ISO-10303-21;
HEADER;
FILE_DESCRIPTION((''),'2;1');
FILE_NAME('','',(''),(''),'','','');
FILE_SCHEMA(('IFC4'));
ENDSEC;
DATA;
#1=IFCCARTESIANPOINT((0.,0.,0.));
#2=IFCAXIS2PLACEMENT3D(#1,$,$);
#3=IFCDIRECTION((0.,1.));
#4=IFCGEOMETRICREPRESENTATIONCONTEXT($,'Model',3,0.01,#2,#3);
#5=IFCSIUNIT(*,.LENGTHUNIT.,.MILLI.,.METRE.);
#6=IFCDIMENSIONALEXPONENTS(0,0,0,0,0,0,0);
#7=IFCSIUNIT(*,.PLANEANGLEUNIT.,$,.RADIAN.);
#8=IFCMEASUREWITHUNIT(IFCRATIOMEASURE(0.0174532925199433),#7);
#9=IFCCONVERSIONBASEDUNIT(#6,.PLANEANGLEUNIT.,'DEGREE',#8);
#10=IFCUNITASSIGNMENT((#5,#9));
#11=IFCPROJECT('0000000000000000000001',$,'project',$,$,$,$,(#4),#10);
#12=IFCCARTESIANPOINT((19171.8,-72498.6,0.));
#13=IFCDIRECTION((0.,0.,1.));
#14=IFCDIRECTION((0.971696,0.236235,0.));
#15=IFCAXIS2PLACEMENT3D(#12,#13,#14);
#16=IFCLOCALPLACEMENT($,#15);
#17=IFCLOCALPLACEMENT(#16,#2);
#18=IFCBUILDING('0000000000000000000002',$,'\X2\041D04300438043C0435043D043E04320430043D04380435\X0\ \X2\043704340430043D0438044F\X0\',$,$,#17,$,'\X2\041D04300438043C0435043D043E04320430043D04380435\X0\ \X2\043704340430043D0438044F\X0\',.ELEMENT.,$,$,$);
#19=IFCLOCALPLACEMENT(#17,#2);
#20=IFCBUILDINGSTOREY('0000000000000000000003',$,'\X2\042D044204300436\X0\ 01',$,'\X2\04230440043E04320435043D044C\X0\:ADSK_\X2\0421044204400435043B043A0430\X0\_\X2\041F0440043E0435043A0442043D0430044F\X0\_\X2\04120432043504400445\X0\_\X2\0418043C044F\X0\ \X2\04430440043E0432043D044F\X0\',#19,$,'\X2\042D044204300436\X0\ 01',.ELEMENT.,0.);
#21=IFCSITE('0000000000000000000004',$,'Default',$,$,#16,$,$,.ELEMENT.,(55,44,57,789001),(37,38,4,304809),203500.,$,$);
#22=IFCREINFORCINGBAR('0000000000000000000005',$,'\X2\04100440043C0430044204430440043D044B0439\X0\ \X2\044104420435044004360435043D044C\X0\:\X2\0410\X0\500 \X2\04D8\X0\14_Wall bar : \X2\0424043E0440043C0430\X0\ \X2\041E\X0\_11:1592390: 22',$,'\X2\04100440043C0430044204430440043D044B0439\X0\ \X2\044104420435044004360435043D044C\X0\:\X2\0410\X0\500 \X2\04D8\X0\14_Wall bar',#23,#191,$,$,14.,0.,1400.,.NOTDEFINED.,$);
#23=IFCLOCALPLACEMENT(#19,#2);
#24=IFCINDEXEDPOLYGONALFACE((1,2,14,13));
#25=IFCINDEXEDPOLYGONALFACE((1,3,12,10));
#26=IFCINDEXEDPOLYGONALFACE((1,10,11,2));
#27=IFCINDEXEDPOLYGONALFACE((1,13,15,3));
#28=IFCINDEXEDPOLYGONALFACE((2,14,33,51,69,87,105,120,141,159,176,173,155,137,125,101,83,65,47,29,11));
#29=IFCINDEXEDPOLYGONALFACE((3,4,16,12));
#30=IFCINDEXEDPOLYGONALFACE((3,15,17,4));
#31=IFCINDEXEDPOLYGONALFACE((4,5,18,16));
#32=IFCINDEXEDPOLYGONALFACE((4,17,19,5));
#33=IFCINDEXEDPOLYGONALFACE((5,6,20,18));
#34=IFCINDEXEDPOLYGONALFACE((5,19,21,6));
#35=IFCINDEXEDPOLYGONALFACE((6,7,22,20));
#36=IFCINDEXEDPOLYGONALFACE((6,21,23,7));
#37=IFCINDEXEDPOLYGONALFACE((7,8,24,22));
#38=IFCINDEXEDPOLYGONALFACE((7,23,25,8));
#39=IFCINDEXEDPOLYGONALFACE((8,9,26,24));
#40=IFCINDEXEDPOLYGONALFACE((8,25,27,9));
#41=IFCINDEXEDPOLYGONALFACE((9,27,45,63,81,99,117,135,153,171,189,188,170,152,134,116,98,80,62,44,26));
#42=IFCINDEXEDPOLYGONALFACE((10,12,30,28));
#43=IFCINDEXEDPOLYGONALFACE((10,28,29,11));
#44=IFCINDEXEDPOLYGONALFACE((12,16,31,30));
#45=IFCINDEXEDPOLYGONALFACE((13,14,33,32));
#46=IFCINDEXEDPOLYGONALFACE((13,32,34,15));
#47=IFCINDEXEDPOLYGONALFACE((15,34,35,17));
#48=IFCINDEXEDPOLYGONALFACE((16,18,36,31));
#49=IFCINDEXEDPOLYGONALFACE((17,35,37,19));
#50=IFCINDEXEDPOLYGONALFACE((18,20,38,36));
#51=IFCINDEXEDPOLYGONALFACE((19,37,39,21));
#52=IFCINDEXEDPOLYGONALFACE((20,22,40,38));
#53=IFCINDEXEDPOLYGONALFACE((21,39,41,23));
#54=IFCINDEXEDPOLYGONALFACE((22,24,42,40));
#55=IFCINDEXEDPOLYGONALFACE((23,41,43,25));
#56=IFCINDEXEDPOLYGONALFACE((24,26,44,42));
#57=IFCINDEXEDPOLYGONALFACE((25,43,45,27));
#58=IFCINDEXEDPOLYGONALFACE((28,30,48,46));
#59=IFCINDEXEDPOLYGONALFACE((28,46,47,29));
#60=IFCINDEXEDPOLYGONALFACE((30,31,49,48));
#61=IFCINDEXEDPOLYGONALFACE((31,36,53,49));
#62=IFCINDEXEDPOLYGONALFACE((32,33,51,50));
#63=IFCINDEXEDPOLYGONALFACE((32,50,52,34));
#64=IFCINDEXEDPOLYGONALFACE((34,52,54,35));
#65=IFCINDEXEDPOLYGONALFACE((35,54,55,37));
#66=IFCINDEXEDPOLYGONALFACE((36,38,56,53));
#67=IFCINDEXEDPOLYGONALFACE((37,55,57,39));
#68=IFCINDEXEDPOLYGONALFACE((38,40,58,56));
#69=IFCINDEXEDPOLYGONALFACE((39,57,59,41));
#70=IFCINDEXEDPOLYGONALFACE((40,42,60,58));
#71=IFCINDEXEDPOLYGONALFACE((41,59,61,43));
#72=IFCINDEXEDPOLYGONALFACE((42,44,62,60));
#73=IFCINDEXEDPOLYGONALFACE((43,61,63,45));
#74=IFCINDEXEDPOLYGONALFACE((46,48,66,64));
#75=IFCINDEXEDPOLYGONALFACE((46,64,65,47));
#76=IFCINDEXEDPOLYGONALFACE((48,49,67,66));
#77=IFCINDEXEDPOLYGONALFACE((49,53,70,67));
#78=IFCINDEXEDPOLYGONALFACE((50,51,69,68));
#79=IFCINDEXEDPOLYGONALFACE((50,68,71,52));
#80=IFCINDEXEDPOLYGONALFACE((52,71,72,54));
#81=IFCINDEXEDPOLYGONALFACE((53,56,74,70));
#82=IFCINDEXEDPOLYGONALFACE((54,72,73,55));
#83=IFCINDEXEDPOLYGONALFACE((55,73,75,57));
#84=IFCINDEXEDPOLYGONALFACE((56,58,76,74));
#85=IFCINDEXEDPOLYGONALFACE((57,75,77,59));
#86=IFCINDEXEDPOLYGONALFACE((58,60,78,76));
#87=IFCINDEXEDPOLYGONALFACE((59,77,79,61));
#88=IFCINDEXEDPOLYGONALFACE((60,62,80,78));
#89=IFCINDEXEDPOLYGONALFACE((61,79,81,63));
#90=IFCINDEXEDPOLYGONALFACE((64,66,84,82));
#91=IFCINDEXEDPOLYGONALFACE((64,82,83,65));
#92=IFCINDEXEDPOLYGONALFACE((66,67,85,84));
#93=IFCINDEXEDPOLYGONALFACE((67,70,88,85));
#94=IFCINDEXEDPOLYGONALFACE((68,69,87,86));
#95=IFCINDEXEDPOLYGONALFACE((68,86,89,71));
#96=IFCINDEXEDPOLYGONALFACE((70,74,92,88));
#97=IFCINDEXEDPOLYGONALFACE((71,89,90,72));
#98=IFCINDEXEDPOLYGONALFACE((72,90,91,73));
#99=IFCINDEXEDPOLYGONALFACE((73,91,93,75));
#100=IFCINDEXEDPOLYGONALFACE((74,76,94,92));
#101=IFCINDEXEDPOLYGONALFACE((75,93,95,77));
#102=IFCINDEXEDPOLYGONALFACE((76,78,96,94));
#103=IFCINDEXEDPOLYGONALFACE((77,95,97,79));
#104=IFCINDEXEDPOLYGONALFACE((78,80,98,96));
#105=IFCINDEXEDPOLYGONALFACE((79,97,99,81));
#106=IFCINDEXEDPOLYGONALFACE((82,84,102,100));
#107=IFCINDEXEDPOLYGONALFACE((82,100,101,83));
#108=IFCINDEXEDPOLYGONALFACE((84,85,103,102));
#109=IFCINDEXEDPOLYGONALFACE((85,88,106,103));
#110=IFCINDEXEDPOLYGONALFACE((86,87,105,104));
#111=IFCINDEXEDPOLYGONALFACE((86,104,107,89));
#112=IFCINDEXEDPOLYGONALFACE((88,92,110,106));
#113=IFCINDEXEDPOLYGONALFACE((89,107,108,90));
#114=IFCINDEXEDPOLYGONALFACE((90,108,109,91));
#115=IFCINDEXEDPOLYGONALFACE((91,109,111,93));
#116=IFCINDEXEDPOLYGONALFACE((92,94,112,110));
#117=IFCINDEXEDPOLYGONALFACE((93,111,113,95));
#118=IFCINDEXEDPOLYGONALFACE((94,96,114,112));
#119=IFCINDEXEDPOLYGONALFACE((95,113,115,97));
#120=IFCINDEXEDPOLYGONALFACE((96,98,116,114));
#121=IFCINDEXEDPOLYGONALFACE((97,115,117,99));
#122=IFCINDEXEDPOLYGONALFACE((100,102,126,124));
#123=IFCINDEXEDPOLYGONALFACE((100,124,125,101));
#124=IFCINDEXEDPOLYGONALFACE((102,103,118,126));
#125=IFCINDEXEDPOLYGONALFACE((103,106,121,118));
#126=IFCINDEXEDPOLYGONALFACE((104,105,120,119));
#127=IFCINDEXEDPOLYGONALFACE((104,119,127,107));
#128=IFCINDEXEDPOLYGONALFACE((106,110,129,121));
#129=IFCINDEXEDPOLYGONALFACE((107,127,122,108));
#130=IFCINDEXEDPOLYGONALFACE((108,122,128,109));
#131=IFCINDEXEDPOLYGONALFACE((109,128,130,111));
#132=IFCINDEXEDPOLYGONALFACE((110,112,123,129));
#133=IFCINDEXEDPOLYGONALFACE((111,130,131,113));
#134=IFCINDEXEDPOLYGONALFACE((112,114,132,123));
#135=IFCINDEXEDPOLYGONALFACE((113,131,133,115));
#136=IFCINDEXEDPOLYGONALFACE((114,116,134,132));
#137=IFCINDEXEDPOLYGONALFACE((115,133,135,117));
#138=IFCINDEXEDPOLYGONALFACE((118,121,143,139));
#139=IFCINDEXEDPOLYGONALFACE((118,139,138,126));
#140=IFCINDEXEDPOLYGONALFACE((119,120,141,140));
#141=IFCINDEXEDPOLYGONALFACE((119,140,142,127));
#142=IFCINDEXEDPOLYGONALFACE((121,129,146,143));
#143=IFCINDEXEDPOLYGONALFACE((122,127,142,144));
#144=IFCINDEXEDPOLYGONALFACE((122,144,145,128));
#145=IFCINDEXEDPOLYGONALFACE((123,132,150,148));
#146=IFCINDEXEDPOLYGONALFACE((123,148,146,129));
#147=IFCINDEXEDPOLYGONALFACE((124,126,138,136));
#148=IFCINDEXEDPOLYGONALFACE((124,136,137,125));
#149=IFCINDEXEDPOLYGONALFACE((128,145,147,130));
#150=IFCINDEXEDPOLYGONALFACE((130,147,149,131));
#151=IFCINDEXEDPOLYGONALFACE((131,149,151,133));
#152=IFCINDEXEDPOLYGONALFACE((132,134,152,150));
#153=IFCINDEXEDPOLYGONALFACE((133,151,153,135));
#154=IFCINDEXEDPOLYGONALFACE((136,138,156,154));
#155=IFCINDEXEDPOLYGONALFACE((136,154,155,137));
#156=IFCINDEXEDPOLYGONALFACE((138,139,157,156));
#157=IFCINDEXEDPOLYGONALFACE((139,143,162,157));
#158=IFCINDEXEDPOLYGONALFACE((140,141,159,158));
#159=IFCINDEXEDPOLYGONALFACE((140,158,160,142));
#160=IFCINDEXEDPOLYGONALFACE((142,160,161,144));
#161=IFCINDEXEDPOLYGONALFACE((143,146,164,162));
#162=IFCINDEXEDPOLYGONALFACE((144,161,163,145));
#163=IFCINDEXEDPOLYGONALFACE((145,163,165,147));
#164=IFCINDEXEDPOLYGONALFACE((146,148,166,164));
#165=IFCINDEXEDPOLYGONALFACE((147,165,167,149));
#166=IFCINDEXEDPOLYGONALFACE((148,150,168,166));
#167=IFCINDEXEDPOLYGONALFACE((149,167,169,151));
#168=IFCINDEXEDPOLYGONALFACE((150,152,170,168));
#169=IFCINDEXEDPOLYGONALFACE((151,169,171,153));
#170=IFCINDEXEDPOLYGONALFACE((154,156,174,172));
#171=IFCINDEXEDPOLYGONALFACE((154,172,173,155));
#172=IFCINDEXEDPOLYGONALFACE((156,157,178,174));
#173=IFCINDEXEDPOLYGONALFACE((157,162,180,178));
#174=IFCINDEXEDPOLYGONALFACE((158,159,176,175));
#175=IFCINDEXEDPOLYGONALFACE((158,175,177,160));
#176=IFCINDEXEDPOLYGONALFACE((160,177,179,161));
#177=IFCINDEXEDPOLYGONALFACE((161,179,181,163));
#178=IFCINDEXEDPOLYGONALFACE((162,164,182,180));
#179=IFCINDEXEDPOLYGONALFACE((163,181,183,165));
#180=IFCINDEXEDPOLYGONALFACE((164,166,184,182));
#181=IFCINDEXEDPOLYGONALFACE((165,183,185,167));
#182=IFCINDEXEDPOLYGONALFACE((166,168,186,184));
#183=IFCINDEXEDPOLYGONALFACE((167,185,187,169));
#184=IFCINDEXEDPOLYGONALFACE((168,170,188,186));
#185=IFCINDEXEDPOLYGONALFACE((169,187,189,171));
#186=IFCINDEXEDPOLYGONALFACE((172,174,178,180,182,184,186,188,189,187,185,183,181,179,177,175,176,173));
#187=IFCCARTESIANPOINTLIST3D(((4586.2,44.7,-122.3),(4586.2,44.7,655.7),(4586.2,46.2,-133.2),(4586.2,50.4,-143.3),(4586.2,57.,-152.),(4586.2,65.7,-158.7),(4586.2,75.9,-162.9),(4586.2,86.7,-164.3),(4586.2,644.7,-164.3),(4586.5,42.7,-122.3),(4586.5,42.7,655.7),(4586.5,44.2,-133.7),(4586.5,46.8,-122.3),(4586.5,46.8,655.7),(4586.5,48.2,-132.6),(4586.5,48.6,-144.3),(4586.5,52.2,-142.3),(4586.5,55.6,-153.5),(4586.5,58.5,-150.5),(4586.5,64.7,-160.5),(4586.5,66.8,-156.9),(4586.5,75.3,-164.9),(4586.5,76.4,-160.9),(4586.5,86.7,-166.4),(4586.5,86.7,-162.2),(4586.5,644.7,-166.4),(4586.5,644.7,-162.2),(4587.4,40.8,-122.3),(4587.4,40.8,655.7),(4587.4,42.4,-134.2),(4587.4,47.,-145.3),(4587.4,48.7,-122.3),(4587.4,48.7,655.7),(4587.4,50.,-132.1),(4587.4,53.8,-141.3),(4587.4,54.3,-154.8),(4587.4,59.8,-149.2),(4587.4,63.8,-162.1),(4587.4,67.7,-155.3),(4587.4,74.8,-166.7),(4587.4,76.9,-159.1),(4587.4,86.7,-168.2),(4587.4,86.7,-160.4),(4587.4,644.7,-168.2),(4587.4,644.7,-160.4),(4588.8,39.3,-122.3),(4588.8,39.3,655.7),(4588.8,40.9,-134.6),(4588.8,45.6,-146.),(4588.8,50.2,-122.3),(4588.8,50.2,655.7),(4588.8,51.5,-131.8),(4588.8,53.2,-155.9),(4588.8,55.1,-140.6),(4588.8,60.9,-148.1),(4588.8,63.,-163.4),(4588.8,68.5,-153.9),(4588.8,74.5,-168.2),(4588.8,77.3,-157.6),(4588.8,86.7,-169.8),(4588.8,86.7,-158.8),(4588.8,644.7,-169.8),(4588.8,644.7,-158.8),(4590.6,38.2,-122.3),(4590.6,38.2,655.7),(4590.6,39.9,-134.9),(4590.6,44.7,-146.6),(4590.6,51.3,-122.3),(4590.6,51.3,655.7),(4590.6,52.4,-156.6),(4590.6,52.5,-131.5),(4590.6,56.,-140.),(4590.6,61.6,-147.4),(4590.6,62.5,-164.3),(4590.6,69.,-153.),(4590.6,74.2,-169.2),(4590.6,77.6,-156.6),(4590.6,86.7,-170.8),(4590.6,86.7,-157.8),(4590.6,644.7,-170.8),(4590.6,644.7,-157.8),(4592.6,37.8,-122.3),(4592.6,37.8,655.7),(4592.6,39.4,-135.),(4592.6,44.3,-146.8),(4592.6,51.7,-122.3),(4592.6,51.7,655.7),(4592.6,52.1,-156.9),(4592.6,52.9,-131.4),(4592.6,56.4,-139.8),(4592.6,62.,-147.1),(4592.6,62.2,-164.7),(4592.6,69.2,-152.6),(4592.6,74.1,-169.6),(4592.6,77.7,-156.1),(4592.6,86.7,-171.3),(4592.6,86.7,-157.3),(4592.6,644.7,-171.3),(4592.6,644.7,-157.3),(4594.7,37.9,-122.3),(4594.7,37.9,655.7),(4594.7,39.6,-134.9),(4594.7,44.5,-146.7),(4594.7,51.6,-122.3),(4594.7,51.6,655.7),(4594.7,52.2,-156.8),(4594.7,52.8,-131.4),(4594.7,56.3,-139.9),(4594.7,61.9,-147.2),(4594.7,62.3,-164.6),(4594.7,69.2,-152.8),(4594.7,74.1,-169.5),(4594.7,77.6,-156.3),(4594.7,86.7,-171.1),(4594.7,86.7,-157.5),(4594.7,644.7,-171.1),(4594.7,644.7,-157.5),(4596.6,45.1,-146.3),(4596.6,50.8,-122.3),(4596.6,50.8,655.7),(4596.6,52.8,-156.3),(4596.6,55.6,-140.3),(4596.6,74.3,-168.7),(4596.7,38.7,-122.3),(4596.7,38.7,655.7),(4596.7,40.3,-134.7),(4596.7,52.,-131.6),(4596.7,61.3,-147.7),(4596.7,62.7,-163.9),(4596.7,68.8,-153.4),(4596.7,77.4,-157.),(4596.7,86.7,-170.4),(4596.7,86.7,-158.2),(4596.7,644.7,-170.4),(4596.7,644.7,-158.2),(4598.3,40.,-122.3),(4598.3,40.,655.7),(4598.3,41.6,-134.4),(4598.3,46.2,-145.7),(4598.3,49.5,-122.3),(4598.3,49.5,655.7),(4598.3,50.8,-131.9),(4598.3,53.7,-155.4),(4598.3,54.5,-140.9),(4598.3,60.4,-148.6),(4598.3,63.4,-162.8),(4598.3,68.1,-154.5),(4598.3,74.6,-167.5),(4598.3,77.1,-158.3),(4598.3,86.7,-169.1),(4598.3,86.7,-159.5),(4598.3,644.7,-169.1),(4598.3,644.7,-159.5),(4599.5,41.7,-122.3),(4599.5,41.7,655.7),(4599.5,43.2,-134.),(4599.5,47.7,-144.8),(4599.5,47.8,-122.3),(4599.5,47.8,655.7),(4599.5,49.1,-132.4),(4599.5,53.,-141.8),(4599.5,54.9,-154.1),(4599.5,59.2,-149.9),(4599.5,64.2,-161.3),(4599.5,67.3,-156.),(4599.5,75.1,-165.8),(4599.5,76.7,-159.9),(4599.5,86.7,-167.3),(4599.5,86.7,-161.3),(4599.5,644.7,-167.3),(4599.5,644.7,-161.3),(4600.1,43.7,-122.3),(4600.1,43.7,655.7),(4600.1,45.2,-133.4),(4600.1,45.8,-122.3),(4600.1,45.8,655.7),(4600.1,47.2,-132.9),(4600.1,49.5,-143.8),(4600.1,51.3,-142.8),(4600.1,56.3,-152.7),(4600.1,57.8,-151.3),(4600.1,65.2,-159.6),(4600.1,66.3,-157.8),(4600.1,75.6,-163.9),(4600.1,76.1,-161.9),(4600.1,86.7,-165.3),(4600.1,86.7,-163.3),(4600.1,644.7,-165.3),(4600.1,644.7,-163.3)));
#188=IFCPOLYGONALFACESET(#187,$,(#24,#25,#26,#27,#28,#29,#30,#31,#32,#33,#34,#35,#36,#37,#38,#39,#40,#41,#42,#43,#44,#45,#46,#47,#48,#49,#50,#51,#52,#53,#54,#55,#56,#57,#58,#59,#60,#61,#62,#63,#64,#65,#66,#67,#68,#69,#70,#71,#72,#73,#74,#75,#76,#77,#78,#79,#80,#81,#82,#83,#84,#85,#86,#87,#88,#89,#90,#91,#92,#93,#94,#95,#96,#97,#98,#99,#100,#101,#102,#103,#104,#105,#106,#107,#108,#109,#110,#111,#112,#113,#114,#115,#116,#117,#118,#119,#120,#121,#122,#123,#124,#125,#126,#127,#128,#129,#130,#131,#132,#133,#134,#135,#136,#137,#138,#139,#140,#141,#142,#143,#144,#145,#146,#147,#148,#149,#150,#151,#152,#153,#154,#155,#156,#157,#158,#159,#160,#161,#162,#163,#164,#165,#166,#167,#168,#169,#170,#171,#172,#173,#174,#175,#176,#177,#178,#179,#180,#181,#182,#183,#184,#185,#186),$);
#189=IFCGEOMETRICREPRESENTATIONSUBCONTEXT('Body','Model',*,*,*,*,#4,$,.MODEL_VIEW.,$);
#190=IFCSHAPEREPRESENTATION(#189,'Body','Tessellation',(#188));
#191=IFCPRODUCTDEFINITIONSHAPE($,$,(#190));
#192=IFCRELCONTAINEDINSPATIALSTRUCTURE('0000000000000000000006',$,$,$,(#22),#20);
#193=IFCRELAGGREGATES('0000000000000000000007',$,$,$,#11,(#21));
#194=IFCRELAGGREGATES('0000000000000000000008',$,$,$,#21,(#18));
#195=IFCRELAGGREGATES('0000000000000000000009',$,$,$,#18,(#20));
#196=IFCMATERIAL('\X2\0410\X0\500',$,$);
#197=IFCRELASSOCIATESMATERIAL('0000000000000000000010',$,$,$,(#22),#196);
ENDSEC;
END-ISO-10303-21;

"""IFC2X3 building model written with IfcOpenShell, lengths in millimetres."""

from ifc_helpers import new_model, entity, si_unit, converted_unit, direction, frame, origin, place, context, subcontext, project, spatial, material, element, save


model = new_model("IFC2X3")

# Units and contexts
model_context = context("Model", 3, precision=0.01, world=origin(), true_north=direction((0.0, 1.0)))
body_context = subcontext(model_context, "Body", "Model", "MODEL_VIEW")
ifc_project = project(units=[si_unit("LENGTHUNIT", "METRE", prefix="MILLI"), converted_unit("PLANEANGLEUNIT", "DEGREE", entity("IfcRatioMeasure", 0.0174532925199433), si_unit("PLANEANGLEUNIT", "RADIAN"), dimensions=[0, 0, 0, 0, 0, 0, 0])], contexts=[model_context])

# Site, building, storey
site_placement = place(None, frame((19171.8, -72498.6, 0.0), z_axis=(0.0, 0.0, 1.0), x_axis=(0.971696, 0.236235, 0.0)))
site = spatial("IfcSite", under=ifc_project, at=site_placement, Name="Default", CompositionType="ELEMENT", RefLatitude=(55, 44, 57, 789001), RefLongitude=(37, 38, 4, 304809), RefElevation=203500.0)
building_placement = place(site_placement, origin())
building = spatial("IfcBuilding", under=site, at=building_placement, Name="Наименование здания", LongName="Наименование здания", CompositionType="ELEMENT")
storey_placement = place(building_placement, origin())
storey = spatial("IfcBuildingStorey", under=building, at=storey_placement, Name="Этаж 01", ObjectType="Уровень:ADSK_Стрелка_Проектная_Вверх_Имя уровня", LongName="Этаж 01", CompositionType="ELEMENT", Elevation=0.0)

# Reinforcing bar
ifc_material = material(Name="А500")
placement = place(storey_placement, origin())
element("IfcReinforcingBar", 1, at=placement, inside=storey, material=ifc_material, Name="Арматурный стержень:А500 Ә14_Wall bar : Форма О_11:1592390: 22", ObjectType="Арматурный стержень:А500 Ә14_Wall bar", BarLength=1400.0, BarRole="NOTDEFINED", CrossSectionArea=0.0, NominalDiameter=14.0, context=body_context, shape_type="AdvancedSweptSolid", body=[
    entity("IfcSweptDiskSolid", entity("IfcCompositeCurve", [entity("IfcCompositeCurveSegment", "CONTINUOUS", True, entity("IfcPolyline", [entity("IfcCartesianPoint", [4593.1, 44.7, 655.7]), entity("IfcCartesianPoint", [4593.1, 44.7, -122.3])])), entity("IfcCompositeCurveSegment", "CONTINUOUS", True, entity("IfcTrimmedCurve", entity("IfcCircle", entity("IfcAxis2Placement3D", entity("IfcCartesianPoint", [4593.1, 86.7, -122.3]), entity("IfcDirection", [1.0, 0.0, 0.0]), entity("IfcDirection", [0.0, 0.0, -1.0])), 42.0), [entity("IfcParameterValue", 270.0)], [entity("IfcParameterValue", 360.0)], True, "PARAMETER")), entity("IfcCompositeCurveSegment", "CONTINUOUS", True, entity("IfcPolyline", [entity("IfcCartesianPoint", [4593.1, 86.7, -164.3]), entity("IfcCartesianPoint", [4593.1, 644.7, -164.3])]))], False), 7.0, None, 0.0, 92.0),
])

save(model, "model.ifc")
